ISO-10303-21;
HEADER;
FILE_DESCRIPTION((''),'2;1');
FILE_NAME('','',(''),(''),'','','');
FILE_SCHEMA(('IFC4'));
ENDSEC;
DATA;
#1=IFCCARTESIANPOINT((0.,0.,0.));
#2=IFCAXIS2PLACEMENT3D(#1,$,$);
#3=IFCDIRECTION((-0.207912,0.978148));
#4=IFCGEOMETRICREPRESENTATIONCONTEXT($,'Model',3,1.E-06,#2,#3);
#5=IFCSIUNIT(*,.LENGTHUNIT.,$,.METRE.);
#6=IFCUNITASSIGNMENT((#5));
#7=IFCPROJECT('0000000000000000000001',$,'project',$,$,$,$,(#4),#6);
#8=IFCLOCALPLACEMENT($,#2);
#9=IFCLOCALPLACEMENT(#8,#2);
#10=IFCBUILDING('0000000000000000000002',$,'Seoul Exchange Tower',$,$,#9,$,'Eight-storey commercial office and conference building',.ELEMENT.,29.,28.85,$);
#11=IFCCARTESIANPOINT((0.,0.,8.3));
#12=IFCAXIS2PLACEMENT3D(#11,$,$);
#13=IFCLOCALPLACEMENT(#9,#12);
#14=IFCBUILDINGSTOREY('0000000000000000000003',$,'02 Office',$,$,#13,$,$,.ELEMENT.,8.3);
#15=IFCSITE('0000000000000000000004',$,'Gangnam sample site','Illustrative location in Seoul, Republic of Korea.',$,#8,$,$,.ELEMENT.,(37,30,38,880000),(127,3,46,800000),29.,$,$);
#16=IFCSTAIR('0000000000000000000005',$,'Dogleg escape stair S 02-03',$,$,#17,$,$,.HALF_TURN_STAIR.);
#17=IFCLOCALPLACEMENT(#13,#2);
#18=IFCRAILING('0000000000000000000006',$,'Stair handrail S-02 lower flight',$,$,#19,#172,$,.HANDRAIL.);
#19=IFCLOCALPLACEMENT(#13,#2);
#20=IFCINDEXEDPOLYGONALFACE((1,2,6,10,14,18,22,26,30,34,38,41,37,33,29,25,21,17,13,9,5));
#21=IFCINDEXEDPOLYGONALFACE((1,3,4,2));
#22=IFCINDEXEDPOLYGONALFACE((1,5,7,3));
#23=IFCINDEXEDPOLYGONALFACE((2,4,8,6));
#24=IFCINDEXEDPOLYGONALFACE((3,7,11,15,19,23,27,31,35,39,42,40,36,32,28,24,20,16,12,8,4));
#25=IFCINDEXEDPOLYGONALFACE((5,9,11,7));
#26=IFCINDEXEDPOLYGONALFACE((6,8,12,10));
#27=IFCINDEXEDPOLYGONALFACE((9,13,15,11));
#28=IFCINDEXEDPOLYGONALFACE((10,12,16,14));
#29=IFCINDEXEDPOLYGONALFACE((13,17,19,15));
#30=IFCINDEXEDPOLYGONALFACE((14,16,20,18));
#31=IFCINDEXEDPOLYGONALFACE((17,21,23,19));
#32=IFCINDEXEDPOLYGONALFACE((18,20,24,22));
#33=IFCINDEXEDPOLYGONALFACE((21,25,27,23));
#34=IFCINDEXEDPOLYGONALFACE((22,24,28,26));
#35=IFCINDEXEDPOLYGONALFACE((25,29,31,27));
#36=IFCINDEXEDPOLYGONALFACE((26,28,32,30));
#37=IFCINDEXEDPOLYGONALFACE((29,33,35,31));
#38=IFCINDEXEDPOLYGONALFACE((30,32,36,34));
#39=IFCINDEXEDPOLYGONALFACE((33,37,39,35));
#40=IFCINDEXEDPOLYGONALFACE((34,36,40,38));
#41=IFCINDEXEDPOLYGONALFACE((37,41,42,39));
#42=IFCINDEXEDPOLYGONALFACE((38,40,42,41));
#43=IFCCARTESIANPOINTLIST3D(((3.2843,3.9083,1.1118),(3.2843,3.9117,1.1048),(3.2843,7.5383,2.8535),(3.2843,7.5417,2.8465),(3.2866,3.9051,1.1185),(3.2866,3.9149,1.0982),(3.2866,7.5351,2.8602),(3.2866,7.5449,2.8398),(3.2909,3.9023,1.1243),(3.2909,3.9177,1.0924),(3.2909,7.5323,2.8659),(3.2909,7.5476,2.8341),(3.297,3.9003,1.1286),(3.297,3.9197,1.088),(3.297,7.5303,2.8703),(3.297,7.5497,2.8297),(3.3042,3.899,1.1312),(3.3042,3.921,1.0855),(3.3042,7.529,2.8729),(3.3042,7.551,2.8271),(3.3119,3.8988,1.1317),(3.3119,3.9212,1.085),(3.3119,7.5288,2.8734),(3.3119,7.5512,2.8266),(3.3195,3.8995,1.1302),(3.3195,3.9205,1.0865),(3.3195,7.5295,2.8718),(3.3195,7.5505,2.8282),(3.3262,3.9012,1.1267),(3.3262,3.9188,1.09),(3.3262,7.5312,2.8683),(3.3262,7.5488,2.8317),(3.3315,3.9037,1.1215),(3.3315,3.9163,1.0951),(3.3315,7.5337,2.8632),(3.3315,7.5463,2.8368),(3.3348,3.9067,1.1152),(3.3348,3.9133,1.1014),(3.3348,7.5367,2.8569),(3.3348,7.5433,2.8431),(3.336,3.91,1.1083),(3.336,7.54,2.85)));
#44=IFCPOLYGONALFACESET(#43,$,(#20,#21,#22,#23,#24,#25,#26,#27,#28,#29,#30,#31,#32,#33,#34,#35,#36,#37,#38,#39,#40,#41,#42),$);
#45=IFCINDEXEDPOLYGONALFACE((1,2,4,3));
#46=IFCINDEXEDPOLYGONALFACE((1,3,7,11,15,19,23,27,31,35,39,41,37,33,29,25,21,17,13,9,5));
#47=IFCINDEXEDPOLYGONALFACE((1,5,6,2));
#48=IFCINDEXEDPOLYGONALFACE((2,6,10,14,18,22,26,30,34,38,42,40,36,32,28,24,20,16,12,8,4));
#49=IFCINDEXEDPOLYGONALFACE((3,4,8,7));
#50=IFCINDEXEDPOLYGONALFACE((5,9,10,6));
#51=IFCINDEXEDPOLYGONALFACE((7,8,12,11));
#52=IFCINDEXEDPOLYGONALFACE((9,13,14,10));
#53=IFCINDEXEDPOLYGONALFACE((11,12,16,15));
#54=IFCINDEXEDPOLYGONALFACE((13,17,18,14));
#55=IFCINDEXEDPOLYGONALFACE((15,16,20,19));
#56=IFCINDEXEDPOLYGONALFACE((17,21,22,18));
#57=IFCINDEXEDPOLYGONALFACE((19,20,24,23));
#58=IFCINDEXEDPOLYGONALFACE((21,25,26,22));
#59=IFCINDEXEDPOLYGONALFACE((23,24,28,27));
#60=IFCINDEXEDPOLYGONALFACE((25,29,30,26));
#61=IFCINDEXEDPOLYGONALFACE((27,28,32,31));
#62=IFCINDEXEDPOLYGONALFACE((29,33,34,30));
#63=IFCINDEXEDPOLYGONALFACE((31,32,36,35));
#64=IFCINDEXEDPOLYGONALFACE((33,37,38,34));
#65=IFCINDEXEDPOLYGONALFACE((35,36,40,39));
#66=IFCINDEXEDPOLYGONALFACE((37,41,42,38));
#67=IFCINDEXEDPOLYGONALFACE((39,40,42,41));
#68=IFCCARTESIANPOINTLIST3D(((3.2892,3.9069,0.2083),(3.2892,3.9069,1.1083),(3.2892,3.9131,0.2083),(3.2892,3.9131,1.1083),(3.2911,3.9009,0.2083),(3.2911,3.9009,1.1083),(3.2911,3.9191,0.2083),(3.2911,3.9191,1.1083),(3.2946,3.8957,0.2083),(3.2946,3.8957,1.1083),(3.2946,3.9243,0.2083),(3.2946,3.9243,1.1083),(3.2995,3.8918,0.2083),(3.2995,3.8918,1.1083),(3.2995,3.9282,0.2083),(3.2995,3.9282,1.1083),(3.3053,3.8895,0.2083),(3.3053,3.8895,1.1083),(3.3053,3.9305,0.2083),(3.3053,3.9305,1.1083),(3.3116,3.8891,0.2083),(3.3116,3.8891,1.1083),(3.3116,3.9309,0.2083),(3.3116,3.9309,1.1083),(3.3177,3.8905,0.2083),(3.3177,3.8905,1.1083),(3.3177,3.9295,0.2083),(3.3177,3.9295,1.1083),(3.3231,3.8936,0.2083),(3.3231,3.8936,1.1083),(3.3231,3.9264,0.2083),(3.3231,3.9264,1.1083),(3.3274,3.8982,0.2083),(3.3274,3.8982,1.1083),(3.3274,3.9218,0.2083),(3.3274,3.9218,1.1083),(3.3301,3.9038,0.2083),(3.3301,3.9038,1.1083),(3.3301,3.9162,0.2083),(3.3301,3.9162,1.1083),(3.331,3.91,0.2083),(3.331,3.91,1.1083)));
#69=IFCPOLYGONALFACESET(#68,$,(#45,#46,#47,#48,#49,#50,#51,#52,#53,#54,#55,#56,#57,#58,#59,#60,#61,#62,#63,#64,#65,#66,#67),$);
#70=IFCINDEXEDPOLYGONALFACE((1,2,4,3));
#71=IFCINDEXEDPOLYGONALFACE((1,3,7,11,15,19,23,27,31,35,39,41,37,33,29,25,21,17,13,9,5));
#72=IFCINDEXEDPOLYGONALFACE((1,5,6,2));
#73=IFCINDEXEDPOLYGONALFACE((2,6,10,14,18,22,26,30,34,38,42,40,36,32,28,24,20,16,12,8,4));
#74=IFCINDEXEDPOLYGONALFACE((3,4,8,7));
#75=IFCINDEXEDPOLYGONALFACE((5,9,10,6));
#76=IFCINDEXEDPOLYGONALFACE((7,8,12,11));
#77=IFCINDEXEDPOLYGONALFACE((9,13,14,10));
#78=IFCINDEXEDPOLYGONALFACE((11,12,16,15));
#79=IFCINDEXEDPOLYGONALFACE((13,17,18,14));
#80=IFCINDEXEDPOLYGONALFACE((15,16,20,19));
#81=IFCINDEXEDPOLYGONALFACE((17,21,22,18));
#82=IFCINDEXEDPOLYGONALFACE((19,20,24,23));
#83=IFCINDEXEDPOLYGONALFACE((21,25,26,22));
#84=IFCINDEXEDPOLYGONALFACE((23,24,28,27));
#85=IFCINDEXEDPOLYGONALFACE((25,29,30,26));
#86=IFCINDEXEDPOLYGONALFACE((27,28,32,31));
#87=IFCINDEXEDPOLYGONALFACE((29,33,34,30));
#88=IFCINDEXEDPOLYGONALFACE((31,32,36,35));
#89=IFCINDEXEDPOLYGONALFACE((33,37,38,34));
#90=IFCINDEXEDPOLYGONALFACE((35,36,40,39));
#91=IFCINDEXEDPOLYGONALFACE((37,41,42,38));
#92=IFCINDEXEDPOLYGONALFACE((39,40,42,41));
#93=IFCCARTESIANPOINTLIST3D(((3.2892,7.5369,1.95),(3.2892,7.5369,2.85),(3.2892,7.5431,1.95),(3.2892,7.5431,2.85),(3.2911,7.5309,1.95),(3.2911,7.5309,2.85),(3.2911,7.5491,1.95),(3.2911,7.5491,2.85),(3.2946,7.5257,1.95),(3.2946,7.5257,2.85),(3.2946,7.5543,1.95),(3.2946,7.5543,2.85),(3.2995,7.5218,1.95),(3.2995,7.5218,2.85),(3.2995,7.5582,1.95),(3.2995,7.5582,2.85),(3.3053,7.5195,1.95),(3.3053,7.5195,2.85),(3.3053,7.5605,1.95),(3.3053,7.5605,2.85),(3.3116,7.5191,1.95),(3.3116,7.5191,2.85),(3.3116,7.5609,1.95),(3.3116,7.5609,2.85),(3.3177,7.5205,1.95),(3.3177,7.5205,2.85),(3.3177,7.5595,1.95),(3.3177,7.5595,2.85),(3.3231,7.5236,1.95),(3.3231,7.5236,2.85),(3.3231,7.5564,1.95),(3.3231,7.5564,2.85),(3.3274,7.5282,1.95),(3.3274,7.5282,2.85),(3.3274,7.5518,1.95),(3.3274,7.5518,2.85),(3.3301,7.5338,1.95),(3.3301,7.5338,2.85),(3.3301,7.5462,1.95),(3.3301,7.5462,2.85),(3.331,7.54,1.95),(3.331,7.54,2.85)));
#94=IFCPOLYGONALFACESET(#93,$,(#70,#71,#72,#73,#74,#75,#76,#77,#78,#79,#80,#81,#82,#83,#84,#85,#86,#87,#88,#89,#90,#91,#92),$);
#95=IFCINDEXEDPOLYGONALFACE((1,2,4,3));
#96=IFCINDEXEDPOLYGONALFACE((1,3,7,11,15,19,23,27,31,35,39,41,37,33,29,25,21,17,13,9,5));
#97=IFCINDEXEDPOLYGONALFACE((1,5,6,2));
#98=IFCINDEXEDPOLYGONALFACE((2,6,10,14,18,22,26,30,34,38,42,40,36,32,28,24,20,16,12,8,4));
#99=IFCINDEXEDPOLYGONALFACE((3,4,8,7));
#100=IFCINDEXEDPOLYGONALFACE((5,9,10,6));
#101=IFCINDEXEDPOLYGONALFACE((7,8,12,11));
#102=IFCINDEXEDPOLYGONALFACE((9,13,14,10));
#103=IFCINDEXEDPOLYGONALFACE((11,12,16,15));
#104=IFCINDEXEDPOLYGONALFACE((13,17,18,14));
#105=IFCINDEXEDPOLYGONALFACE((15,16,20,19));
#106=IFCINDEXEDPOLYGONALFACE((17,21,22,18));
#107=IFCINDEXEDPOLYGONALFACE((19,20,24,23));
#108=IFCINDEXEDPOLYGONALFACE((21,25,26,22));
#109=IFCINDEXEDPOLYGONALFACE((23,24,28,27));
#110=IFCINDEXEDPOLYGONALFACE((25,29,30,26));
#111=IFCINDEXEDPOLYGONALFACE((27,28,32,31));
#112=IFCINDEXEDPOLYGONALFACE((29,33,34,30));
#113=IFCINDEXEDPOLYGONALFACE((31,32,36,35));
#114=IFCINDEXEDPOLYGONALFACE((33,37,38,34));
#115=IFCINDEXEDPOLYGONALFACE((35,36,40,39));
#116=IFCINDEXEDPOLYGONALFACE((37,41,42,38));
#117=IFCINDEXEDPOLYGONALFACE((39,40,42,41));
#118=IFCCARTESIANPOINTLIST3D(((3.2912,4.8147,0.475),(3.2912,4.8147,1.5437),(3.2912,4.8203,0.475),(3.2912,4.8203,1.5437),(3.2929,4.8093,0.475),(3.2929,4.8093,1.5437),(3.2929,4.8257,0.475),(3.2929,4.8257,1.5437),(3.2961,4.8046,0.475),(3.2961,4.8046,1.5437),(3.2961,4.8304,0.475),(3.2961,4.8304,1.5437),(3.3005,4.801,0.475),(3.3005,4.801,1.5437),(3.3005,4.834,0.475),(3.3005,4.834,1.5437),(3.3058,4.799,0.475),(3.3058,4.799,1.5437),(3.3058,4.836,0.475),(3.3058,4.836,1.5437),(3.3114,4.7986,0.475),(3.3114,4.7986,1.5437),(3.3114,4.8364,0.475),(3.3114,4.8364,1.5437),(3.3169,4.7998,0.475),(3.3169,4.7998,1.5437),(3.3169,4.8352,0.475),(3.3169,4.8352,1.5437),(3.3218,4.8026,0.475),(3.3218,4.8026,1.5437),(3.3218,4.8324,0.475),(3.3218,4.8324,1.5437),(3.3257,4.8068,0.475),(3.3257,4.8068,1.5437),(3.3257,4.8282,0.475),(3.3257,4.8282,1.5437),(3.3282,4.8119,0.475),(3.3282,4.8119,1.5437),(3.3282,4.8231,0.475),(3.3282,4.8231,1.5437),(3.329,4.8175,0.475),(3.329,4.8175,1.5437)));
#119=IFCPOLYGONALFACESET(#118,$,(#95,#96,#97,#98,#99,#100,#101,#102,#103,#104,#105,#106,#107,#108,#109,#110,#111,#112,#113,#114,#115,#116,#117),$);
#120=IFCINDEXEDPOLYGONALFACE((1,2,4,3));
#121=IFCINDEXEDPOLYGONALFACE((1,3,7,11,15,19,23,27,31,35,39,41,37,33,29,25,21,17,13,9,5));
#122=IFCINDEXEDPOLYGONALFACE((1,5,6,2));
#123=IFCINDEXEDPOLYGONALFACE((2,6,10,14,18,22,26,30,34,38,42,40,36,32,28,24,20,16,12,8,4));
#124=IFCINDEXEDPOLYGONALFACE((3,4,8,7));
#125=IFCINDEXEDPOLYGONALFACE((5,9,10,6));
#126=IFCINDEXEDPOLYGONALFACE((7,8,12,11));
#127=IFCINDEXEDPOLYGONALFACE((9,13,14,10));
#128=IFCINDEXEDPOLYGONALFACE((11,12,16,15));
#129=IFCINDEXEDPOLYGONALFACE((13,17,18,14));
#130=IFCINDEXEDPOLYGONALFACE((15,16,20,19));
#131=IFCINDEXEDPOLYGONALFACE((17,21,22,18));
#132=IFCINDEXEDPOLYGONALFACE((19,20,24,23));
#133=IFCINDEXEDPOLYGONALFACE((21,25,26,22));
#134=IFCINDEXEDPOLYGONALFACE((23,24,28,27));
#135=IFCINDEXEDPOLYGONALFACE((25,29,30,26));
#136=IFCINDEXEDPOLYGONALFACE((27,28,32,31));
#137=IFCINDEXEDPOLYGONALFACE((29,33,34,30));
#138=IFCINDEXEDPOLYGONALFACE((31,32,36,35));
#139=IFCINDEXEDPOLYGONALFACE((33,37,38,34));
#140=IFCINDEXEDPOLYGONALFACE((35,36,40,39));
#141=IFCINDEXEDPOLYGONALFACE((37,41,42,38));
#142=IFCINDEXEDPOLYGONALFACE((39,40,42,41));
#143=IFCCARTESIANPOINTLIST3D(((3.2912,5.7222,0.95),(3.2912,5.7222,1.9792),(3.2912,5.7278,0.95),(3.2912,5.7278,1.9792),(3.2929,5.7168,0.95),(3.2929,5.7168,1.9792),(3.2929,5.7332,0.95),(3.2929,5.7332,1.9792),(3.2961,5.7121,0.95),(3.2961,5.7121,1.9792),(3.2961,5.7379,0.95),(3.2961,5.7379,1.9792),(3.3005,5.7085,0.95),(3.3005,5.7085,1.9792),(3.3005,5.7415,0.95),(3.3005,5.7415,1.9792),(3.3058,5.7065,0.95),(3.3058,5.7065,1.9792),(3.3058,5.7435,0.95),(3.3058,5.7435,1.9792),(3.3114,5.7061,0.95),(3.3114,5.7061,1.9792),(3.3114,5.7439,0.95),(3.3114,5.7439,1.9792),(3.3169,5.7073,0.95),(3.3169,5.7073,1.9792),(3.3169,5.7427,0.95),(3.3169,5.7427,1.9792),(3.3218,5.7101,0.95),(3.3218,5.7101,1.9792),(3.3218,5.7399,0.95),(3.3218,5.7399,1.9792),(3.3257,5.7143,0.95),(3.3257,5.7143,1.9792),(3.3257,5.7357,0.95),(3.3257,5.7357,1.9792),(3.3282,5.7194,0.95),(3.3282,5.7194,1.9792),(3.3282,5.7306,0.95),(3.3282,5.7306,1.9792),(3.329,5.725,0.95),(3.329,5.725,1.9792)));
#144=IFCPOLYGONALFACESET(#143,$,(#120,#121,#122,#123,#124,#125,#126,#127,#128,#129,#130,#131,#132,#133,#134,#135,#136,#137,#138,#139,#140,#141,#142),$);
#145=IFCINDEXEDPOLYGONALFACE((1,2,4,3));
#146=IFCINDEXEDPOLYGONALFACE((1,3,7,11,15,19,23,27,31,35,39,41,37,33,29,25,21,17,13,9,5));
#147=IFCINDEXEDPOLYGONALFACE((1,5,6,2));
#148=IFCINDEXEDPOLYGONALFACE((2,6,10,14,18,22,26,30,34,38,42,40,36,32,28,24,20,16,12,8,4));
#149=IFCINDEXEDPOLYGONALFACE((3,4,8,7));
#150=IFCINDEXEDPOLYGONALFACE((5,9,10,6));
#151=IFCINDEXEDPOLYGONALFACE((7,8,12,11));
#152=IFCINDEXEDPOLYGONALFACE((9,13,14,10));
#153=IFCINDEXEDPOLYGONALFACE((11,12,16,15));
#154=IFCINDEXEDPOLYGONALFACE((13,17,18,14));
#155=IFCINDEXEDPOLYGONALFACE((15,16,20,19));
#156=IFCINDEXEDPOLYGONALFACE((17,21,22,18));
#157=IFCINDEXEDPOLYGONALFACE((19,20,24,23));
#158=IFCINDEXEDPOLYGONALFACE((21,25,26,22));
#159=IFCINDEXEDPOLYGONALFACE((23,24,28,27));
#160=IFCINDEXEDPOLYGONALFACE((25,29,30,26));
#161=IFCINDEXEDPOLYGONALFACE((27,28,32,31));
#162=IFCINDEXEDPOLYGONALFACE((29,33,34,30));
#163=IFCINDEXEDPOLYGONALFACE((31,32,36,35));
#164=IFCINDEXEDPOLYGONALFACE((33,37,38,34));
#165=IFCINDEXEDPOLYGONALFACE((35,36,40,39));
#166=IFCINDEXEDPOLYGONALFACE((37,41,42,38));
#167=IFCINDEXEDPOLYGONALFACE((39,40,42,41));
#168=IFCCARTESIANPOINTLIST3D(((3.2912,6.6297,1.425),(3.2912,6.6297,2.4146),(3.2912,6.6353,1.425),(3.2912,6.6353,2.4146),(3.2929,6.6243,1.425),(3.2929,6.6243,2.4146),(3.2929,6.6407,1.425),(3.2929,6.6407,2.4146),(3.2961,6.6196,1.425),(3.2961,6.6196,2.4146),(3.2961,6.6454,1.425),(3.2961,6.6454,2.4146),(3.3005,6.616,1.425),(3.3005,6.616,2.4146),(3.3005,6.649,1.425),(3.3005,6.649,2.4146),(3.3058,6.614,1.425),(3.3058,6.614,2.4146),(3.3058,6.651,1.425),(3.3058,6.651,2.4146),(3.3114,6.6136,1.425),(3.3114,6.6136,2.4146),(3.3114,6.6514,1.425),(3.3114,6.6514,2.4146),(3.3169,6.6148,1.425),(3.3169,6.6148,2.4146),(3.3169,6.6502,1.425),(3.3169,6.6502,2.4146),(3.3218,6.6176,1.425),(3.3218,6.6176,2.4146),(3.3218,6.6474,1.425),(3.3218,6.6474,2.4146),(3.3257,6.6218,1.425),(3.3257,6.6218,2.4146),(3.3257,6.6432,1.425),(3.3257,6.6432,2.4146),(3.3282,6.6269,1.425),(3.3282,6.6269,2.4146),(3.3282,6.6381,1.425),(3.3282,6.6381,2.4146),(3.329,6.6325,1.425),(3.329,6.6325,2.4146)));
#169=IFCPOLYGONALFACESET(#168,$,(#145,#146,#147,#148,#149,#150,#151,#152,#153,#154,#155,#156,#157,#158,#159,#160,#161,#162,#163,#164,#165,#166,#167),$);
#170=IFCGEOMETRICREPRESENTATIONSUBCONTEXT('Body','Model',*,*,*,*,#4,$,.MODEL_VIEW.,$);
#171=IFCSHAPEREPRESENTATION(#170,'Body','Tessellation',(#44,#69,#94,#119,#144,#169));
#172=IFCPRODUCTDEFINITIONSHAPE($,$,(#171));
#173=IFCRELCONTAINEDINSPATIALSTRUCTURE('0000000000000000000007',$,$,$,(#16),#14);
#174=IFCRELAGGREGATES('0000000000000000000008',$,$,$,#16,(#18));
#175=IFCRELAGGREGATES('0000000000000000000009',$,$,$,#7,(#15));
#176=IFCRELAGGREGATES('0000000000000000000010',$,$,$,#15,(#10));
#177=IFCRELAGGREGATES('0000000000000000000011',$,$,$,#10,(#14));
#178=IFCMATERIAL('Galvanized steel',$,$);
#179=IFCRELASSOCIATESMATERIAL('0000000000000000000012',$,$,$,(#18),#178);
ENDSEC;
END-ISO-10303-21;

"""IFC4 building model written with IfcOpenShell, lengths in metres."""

from ifc_helpers import new_model, si_unit, direction, frame, origin, place, context, subcontext, project, spatial, circle, extrude, material, element, aggregate, save


model = new_model("IFC4")

# Units and contexts
model_context = context("Model", 3, precision=1e-06, world=origin(), true_north=direction((-0.207912, 0.978148)))
body_context = subcontext(model_context, "Body", "Model", "MODEL_VIEW")
ifc_project = project(units=[si_unit("LENGTHUNIT", "METRE")], contexts=[model_context])

# Site, building, storey
site_placement = place(None, origin())
site = spatial("IfcSite", under=ifc_project, at=site_placement, Name="Gangnam sample site", Description="Illustrative location in Seoul, Republic of Korea.", CompositionType="ELEMENT", RefLatitude=(37, 30, 38, 880000), RefLongitude=(127, 3, 46, 800000), RefElevation=29.0)
building_placement = place(site_placement, origin())
building = spatial("IfcBuilding", under=site, at=building_placement, Name="Seoul Exchange Tower", LongName="Eight-storey commercial office and conference building", CompositionType="ELEMENT", ElevationOfRefHeight=29.0, ElevationOfTerrain=28.85)
storey_placement = place(building_placement, frame((0.0, 0.0, 8.3)))
storey = spatial("IfcBuildingStorey", under=building, at=storey_placement, Name="02 Office", CompositionType="ELEMENT", Elevation=8.3)

# Shared definitions
placement_1 = place(storey_placement, origin())

# Stair
placement_2 = place(placement_1, origin())
stair_1 = element("IfcStair", 1, at=placement_1, inside=storey, Name="Dogleg escape stair S 02-03", PredefinedType="HALF_TURN_STAIR")

# Railing
ifc_material_1 = material(Name="Galvanized steel")
railing_1 = element("IfcRailing", 2, at=placement_2, material=ifc_material_1, Name="Stair handrail S-02 lower flight", PredefinedType="HANDRAIL", context=body_context, shape_type="SweptSolid", body=[
    extrude(circle(Radius=0.026), frame((3.31, 3.91, 1.1083), z_axis=(0.0, 0.901594, 0.432583), x_axis=(1.0, 0.0, 0.0)), (0.0, 0.0, 1.0), 4.0262),
    extrude(circle(Radius=0.021), frame((3.31, 3.91, 0.2083), z_axis=(0.0, 0.0, 1.0), x_axis=(1.0, 0.0, 0.0)), (0.0, 0.0, 1.0), 0.9),
    extrude(circle(Radius=0.021), frame((3.31, 7.54, 1.95), z_axis=(0.0, 0.0, 1.0), x_axis=(1.0, 0.0, 0.0)), (0.0, 0.0, 1.0), 0.9),
    extrude(circle(Radius=0.019), frame((3.31, 4.8175, 0.475), z_axis=(0.0, 0.0, 1.0), x_axis=(1.0, 0.0, 0.0)), (0.0, 0.0, 1.0), 1.0688),
    extrude(circle(Radius=0.019), frame((3.31, 5.725, 0.95), z_axis=(0.0, 0.0, 1.0), x_axis=(1.0, 0.0, 0.0)), (0.0, 0.0, 1.0), 1.0292),
    extrude(circle(Radius=0.019), frame((3.31, 6.6325, 1.425), z_axis=(0.0, 0.0, 1.0), x_axis=(1.0, 0.0, 0.0)), (0.0, 0.0, 1.0), 0.9896),
])
aggregate(stair_1, [railing_1])

save(model, "model.ifc")
